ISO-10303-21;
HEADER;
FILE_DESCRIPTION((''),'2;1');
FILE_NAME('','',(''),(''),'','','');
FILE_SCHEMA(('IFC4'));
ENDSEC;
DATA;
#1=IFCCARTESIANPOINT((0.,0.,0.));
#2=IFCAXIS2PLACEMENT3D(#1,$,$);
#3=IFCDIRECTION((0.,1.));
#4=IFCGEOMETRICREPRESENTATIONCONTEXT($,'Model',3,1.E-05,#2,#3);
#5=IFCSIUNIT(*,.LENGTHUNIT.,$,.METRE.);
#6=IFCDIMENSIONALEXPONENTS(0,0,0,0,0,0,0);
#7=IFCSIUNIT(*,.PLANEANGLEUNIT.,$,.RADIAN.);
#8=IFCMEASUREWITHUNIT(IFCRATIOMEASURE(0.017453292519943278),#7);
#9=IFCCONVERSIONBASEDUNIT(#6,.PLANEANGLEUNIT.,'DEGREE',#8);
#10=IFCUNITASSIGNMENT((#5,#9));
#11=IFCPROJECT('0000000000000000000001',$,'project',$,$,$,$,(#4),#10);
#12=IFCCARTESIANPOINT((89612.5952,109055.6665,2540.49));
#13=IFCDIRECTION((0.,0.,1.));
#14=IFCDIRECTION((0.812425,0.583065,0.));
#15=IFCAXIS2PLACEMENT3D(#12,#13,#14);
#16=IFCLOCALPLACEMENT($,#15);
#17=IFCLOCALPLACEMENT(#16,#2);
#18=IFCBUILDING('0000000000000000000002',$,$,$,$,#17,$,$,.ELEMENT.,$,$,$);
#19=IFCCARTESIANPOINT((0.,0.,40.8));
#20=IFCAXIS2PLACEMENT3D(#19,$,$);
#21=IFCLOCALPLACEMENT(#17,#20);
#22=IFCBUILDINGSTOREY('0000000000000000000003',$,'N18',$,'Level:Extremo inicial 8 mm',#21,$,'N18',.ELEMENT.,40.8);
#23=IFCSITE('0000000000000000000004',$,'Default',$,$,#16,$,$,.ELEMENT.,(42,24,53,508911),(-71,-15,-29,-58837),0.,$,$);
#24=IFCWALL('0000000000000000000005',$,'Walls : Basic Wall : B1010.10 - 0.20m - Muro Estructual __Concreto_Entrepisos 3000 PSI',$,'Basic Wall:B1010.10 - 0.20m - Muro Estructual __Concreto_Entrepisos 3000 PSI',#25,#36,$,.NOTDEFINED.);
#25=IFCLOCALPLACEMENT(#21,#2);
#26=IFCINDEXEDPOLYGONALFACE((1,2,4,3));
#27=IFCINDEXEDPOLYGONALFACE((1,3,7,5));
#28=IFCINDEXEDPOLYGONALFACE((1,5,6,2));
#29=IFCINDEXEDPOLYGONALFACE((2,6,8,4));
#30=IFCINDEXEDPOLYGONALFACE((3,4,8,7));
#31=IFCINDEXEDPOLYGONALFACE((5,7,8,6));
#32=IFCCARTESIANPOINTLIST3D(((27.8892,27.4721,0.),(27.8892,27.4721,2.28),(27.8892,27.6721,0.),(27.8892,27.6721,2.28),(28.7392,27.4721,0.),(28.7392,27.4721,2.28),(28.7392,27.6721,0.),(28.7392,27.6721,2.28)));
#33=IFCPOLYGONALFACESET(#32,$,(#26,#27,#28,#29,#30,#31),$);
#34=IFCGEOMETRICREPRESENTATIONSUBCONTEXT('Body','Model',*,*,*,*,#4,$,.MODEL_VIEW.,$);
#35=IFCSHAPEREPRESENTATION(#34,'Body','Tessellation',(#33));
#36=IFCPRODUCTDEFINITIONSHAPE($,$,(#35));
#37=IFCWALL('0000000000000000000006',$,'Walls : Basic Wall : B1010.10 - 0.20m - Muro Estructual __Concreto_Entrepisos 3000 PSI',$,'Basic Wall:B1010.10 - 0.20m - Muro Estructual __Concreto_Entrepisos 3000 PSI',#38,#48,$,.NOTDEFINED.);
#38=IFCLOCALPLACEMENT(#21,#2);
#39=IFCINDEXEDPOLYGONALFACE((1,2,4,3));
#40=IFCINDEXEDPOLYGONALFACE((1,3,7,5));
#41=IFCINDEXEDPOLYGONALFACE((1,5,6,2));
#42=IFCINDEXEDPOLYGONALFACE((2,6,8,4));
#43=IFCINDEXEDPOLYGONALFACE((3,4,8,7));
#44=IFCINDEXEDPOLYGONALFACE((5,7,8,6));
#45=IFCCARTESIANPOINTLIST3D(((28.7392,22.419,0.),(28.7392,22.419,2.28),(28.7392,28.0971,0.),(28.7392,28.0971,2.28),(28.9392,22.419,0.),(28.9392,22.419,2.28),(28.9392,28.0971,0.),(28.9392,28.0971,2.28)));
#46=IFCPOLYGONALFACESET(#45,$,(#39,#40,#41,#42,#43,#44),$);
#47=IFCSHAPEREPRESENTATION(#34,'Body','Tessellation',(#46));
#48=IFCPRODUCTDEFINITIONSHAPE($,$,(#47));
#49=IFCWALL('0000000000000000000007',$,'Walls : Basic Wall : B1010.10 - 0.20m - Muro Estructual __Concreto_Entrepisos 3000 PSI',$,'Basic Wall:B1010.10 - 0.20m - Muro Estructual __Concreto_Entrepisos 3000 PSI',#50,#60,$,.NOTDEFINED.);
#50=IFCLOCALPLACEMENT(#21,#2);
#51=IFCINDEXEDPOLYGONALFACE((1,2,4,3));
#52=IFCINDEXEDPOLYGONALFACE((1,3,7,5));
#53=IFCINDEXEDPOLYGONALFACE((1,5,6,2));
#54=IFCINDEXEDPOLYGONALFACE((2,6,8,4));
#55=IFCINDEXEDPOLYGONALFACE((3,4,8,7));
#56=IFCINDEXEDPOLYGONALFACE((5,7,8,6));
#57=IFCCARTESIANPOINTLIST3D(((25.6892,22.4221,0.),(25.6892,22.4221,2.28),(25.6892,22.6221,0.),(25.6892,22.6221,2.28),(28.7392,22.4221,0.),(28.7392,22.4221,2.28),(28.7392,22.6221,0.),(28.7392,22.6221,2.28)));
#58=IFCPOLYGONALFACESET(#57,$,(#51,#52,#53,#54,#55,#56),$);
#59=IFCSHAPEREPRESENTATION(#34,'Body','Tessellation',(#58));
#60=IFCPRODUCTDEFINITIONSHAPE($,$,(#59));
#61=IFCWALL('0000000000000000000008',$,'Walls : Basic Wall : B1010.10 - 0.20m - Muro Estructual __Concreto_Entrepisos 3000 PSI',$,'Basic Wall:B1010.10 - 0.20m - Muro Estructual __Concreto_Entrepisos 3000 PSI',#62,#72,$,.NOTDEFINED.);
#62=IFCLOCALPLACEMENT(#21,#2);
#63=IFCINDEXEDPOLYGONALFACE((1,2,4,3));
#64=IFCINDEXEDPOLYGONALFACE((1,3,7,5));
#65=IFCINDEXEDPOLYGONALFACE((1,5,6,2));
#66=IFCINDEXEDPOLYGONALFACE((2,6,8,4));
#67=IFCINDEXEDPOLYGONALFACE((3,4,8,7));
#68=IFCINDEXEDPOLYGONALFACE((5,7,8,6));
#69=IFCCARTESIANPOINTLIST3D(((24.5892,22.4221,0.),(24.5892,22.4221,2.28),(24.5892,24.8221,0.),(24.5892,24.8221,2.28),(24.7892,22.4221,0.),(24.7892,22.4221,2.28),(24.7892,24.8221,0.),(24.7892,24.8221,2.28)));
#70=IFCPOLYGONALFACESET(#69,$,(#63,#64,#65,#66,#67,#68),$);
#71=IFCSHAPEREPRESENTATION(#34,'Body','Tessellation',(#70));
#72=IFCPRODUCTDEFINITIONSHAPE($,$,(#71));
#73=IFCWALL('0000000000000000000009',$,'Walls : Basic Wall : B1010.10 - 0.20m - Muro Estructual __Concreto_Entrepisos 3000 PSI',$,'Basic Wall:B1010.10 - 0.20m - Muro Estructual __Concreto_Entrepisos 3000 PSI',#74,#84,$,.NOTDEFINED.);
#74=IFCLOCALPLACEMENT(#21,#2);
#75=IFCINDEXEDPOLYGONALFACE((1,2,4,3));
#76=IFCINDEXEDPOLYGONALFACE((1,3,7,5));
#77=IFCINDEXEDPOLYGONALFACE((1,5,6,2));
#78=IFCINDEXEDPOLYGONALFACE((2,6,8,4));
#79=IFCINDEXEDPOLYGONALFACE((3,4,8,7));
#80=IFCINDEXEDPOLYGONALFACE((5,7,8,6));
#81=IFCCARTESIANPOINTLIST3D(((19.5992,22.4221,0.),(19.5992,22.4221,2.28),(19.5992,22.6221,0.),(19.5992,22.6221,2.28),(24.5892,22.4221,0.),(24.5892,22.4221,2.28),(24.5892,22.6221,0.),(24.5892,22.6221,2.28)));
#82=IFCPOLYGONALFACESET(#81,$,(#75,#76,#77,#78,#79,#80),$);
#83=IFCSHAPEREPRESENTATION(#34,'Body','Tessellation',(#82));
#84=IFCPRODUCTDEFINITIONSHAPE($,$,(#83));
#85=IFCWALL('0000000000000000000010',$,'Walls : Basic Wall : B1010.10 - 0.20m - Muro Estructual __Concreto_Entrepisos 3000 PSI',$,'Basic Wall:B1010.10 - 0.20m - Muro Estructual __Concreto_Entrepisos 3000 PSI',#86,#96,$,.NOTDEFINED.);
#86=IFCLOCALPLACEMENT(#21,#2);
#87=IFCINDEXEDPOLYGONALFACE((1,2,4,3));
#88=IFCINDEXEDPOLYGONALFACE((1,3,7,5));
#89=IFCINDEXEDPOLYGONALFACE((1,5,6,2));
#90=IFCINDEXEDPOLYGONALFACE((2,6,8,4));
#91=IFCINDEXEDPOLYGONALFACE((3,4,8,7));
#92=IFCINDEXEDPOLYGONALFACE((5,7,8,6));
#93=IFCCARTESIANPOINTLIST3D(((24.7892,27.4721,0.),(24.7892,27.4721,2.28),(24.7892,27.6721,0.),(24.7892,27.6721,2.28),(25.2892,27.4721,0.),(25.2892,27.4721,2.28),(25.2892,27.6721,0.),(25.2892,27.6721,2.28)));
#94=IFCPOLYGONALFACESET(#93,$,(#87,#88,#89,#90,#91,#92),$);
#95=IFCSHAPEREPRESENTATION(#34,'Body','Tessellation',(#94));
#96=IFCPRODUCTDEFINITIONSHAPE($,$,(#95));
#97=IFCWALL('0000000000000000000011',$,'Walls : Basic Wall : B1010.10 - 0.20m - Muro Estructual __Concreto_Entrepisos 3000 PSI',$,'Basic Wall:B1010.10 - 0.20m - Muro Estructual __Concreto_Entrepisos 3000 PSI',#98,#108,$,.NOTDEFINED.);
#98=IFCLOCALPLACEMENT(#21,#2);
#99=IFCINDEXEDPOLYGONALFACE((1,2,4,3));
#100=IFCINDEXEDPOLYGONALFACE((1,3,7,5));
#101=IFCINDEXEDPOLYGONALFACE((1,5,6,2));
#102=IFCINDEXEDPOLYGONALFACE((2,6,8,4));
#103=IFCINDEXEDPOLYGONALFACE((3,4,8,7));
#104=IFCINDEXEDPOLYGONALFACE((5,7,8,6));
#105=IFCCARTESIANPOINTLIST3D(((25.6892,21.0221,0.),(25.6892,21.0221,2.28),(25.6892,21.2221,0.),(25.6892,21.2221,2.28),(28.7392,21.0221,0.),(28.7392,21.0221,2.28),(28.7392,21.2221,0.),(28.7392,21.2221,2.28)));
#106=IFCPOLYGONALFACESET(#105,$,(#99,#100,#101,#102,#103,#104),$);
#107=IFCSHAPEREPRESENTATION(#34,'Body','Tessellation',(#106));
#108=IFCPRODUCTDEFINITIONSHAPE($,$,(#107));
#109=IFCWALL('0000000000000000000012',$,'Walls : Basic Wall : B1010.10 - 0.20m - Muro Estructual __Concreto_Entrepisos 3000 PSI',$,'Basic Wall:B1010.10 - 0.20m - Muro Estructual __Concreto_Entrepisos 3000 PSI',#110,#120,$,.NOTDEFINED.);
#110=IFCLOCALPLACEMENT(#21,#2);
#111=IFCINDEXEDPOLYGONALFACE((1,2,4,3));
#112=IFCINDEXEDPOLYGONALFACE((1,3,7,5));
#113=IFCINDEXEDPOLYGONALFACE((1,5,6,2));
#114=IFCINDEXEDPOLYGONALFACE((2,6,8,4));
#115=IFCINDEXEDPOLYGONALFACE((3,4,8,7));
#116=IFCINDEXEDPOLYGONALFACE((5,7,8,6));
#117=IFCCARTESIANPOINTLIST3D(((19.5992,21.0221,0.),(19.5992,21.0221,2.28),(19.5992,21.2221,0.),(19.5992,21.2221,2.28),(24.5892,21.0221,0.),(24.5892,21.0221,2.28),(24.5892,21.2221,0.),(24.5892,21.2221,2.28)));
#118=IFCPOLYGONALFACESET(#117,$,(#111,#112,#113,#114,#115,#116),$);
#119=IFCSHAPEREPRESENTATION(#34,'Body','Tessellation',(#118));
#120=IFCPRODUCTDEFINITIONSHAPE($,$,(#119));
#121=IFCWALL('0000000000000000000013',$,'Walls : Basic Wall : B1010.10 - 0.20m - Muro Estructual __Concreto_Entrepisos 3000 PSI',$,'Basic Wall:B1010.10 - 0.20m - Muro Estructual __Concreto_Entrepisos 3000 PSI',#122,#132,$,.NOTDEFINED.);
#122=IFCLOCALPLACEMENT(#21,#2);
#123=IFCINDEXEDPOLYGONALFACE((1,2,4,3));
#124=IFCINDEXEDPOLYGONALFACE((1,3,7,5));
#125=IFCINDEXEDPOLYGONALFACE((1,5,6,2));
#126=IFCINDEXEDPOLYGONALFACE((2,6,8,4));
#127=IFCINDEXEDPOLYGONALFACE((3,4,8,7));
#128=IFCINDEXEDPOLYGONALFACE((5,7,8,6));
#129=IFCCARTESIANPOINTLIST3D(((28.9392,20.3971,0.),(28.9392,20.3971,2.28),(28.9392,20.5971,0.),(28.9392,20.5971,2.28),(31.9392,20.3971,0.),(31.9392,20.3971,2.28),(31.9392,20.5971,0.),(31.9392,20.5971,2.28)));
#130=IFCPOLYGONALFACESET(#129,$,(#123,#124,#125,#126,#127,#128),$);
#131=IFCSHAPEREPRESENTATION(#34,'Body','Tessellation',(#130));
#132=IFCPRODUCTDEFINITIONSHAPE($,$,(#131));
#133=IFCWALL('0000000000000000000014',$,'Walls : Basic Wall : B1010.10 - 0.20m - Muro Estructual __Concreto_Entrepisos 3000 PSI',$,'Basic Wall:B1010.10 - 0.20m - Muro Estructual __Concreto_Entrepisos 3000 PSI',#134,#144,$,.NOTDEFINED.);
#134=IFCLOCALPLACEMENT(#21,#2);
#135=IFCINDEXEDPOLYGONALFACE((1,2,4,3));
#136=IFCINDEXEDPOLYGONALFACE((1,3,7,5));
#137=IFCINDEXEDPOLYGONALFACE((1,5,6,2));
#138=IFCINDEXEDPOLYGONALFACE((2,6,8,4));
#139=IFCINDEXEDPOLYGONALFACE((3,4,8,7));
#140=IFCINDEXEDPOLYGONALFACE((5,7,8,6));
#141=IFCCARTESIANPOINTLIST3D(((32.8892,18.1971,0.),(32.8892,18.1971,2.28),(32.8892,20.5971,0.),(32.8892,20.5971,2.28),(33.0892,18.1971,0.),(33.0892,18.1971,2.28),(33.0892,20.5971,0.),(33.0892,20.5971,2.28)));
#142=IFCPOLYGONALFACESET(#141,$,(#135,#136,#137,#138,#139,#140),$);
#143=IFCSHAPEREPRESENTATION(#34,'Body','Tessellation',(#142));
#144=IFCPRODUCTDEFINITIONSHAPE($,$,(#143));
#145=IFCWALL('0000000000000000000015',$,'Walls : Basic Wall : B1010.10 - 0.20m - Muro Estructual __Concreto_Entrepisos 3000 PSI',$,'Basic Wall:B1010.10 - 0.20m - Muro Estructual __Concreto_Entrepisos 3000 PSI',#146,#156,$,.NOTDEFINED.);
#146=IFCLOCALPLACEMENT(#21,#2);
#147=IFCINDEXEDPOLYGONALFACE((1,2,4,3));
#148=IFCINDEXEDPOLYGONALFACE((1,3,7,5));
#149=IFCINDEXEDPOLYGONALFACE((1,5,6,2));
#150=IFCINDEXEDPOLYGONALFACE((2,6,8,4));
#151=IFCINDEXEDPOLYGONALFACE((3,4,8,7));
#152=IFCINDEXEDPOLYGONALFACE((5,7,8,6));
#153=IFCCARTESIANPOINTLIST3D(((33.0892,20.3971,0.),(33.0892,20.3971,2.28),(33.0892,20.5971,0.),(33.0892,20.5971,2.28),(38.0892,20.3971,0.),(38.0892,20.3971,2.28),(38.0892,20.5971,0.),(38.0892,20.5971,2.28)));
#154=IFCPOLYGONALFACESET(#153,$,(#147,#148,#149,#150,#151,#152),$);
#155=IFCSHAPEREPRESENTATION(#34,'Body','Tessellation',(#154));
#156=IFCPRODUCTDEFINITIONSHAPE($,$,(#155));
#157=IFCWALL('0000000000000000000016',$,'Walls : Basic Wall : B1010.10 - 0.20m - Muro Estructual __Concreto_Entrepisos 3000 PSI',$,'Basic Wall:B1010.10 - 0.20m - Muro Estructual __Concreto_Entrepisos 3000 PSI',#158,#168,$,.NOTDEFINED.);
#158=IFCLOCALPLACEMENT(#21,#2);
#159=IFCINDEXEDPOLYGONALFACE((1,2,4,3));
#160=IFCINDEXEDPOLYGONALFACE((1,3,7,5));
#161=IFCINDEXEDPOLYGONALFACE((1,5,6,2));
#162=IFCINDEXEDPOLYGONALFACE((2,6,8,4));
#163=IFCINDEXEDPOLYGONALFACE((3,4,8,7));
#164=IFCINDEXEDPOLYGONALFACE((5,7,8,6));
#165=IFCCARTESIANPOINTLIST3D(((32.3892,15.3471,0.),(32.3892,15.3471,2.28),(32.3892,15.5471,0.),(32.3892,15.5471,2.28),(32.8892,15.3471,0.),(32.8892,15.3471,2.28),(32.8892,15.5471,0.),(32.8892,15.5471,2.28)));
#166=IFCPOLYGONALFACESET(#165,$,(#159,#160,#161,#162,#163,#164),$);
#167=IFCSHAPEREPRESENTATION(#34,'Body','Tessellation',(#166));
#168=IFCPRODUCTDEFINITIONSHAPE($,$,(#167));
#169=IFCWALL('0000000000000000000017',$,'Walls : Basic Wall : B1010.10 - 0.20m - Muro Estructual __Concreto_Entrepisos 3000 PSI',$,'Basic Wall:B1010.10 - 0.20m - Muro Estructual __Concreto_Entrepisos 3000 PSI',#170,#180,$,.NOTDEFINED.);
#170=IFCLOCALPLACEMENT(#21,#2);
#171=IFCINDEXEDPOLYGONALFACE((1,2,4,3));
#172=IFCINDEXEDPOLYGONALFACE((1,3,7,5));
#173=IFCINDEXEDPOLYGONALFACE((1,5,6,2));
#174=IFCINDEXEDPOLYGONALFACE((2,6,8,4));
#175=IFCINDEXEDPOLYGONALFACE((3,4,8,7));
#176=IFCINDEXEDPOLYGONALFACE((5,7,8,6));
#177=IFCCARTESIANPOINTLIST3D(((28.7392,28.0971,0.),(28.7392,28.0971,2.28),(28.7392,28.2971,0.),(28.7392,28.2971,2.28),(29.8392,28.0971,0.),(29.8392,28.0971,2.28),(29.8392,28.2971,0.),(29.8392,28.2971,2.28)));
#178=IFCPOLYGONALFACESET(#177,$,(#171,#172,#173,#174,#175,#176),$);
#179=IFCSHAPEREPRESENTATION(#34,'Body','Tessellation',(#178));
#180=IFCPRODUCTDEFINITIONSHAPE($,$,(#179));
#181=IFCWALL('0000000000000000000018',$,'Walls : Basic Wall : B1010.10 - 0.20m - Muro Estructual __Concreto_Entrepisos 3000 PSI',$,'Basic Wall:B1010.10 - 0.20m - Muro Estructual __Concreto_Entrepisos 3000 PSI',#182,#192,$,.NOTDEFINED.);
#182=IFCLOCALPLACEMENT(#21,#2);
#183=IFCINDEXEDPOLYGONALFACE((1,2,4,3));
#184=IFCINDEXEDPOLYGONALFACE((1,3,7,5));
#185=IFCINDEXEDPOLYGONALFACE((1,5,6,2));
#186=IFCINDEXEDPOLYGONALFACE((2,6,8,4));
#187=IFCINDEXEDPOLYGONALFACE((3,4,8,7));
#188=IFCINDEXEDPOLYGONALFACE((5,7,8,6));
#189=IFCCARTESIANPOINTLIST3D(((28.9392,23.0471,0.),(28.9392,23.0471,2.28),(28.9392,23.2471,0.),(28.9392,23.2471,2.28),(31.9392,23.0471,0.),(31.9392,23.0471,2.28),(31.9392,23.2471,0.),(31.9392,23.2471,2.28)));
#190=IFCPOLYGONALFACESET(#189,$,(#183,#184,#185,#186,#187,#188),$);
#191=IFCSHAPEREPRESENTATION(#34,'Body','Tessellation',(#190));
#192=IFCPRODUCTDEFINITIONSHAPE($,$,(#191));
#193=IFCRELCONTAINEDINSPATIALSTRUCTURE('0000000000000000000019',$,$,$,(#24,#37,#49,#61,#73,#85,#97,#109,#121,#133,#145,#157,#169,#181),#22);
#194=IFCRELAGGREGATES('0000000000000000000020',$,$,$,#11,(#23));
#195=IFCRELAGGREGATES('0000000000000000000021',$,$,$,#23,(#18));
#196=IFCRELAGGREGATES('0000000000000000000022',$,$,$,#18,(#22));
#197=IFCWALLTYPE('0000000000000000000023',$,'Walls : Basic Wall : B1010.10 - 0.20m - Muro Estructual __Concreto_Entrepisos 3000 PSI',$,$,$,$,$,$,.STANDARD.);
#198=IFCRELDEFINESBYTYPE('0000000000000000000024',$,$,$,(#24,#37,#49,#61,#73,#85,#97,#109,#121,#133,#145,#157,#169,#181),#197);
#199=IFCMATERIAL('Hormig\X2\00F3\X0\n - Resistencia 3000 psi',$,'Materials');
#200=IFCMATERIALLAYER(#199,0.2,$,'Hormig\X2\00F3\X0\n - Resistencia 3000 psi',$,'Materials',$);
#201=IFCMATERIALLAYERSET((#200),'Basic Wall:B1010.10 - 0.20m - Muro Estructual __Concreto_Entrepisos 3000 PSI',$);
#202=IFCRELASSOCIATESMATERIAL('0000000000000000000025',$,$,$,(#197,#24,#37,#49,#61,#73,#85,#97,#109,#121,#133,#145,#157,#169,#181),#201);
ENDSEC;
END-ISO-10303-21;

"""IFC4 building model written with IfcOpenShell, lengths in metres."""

from ifc_helpers import new_model, entity, si_unit, converted_unit, direction, frame, frame_2d, origin, place, context, subcontext, project, spatial, rectangle, extrude, material, layer, layer_set, layer_usage, type_object, element, save


model = new_model("IFC4")

# Units and contexts
model_context = context("Model", 3, precision=1e-05, world=origin(), true_north=direction((0.0, 1.0)))
body_context = subcontext(model_context, "Body", "Model", "MODEL_VIEW")
ifc_project = project(units=[si_unit("LENGTHUNIT", "METRE"), converted_unit("PLANEANGLEUNIT", "DEGREE", entity("IfcRatioMeasure", 0.017453292519943278), si_unit("PLANEANGLEUNIT", "RADIAN"), dimensions=[0, 0, 0, 0, 0, 0, 0])], contexts=[model_context])

# Site, building, storey
site_placement = place(None, frame((89612.5952, 109055.6665, 2540.49), z_axis=(0.0, 0.0, 1.0), x_axis=(0.812425, 0.583065, 0.0)))
site = spatial("IfcSite", under=ifc_project, at=site_placement, Name="Default", CompositionType="ELEMENT", RefLatitude=(42, 24, 53, 508911), RefLongitude=(-71, -15, -29, -58837), RefElevation=0.0)
building_placement = place(site_placement, origin())
building = spatial("IfcBuilding", under=site, at=building_placement, CompositionType="ELEMENT")
storey_placement = place(building_placement, frame((0.0, 0.0, 40.8)))
storey = spatial("IfcBuildingStorey", under=building, at=storey_placement, Name="N18", ObjectType="Level:Extremo inicial 8 mm", LongName="N18", CompositionType="ELEMENT", Elevation=40.8)

# Walls
ifc_material = material(Name="Hormigón - Resistencia 3000 psi", Category="Materials")
ifc_layer_1 = layer(ifc_material, 0.2, Name="Hormigón - Resistencia 3000 psi", Category="Materials")
ifc_layer_set_1 = layer_set([ifc_layer_1], Name="Basic Wall:B1010.10 - 0.20m - Muro Estructual __Concreto_Entrepisos 3000 PSI")
ifc_layer_usage_1 = layer_usage(ifc_layer_set_1, "AXIS2", "NEGATIVE", 0.1)
wall_type_1 = type_object("IfcWallType", Name="Walls : Basic Wall : B1010.10 - 0.20m - Muro Estructual __Concreto_Entrepisos 3000 PSI", PredefinedType="STANDARD", material=ifc_layer_set_1)
wall_1_placement = place(storey_placement, frame((27.8892, 27.5721, 0.0)))
element("IfcWall", 1, at=wall_1_placement, inside=storey, type_object=wall_type_1, material=ifc_layer_usage_1, Name="Walls : Basic Wall : B1010.10 - 0.20m - Muro Estructual __Concreto_Entrepisos 3000 PSI", ObjectType="Basic Wall:B1010.10 - 0.20m - Muro Estructual __Concreto_Entrepisos 3000 PSI", PredefinedType="NOTDEFINED", context=body_context, shape_type="SweptSolid", body=[
    extrude(rectangle(XDim=0.85, YDim=0.2, at=frame_2d((0.425, 0.0), x_axis=(-1.0, 0.0))), origin(), (0.0, 0.0, 1.0), 2.28),
])
ifc_layer_usage_2 = layer_usage(ifc_layer_set_1, "AXIS2", "NEGATIVE", 0.1)
wall_2_placement = place(storey_placement, frame((28.8392, 28.0971, 0.0), z_axis=(0.0, 0.0, 1.0), x_axis=(0.0, -1.0, 0.0)))
element("IfcWall", 2, at=wall_2_placement, inside=storey, type_object=wall_type_1, material=ifc_layer_usage_2, Name="Walls : Basic Wall : B1010.10 - 0.20m - Muro Estructual __Concreto_Entrepisos 3000 PSI", ObjectType="Basic Wall:B1010.10 - 0.20m - Muro Estructual __Concreto_Entrepisos 3000 PSI", PredefinedType="NOTDEFINED", context=body_context, shape_type="SweptSolid", body=[
    extrude(rectangle(XDim=5.6781, YDim=0.2, at=frame_2d((2.839, 0.0), x_axis=(-1.0, 0.0))), origin(), (0.0, 0.0, 1.0), 2.28),
])
ifc_layer_usage_3 = layer_usage(ifc_layer_set_1, "AXIS2", "NEGATIVE", 0.1)
wall_3_placement = place(storey_placement, frame((28.7392, 22.5221, 0.0), z_axis=(0.0, 0.0, 1.0), x_axis=(-1.0, 0.0, 0.0)))
element("IfcWall", 3, at=wall_3_placement, inside=storey, type_object=wall_type_1, material=ifc_layer_usage_3, Name="Walls : Basic Wall : B1010.10 - 0.20m - Muro Estructual __Concreto_Entrepisos 3000 PSI", ObjectType="Basic Wall:B1010.10 - 0.20m - Muro Estructual __Concreto_Entrepisos 3000 PSI", PredefinedType="NOTDEFINED", context=body_context, shape_type="SweptSolid", body=[
    extrude(rectangle(XDim=3.05, YDim=0.2, at=frame_2d((1.525, 0.0), x_axis=(-1.0, 0.0))), origin(), (0.0, 0.0, 1.0), 2.28),
])
ifc_layer_usage_4 = layer_usage(ifc_layer_set_1, "AXIS2", "NEGATIVE", 0.1)
wall_4_placement = place(storey_placement, frame((24.6892, 24.8221, 0.0), z_axis=(0.0, 0.0, 1.0), x_axis=(0.0, -1.0, 0.0)))
element("IfcWall", 4, at=wall_4_placement, inside=storey, type_object=wall_type_1, material=ifc_layer_usage_4, Name="Walls : Basic Wall : B1010.10 - 0.20m - Muro Estructual __Concreto_Entrepisos 3000 PSI", ObjectType="Basic Wall:B1010.10 - 0.20m - Muro Estructual __Concreto_Entrepisos 3000 PSI", PredefinedType="NOTDEFINED", context=body_context, shape_type="SweptSolid", body=[
    extrude(rectangle(XDim=2.4, YDim=0.2, at=frame_2d((1.2, 0.0), x_axis=(-1.0, 0.0))), origin(), (0.0, 0.0, 1.0), 2.28),
])
ifc_layer_usage_5 = layer_usage(ifc_layer_set_1, "AXIS2", "NEGATIVE", 0.1)
wall_5_placement = place(storey_placement, frame((24.5892, 22.5221, 0.0), z_axis=(0.0, 0.0, 1.0), x_axis=(-1.0, 0.0, 0.0)))
element("IfcWall", 5, at=wall_5_placement, inside=storey, type_object=wall_type_1, material=ifc_layer_usage_5, Name="Walls : Basic Wall : B1010.10 - 0.20m - Muro Estructual __Concreto_Entrepisos 3000 PSI", ObjectType="Basic Wall:B1010.10 - 0.20m - Muro Estructual __Concreto_Entrepisos 3000 PSI", PredefinedType="NOTDEFINED", context=body_context, shape_type="SweptSolid", body=[
    extrude(rectangle(XDim=4.99, YDim=0.2, at=frame_2d((2.495, 0.0), x_axis=(-1.0, 0.0))), origin(), (0.0, 0.0, 1.0), 2.28),
])
ifc_layer_usage_6 = layer_usage(ifc_layer_set_1, "AXIS2", "NEGATIVE", 0.1)
wall_6_placement = place(storey_placement, frame((25.2892, 27.5721, 0.0), z_axis=(0.0, 0.0, 1.0), x_axis=(-1.0, 0.0, 0.0)))
element("IfcWall", 6, at=wall_6_placement, inside=storey, type_object=wall_type_1, material=ifc_layer_usage_6, Name="Walls : Basic Wall : B1010.10 - 0.20m - Muro Estructual __Concreto_Entrepisos 3000 PSI", ObjectType="Basic Wall:B1010.10 - 0.20m - Muro Estructual __Concreto_Entrepisos 3000 PSI", PredefinedType="NOTDEFINED", context=body_context, shape_type="SweptSolid", body=[
    extrude(rectangle(XDim=0.5, YDim=0.2, at=frame_2d((0.25, 0.0), x_axis=(-1.0, 0.0))), origin(), (0.0, 0.0, 1.0), 2.28),
])
ifc_layer_usage_7 = layer_usage(ifc_layer_set_1, "AXIS2", "POSITIVE", -0.1)
wall_7_placement = place(storey_placement, frame((28.7392, 21.1221, 0.0), z_axis=(0.0, 0.0, 1.0), x_axis=(-1.0, 0.0, 0.0)))
element("IfcWall", 7, at=wall_7_placement, inside=storey, type_object=wall_type_1, material=ifc_layer_usage_7, Name="Walls : Basic Wall : B1010.10 - 0.20m - Muro Estructual __Concreto_Entrepisos 3000 PSI", ObjectType="Basic Wall:B1010.10 - 0.20m - Muro Estructual __Concreto_Entrepisos 3000 PSI", PredefinedType="NOTDEFINED", context=body_context, shape_type="SweptSolid", body=[
    extrude(rectangle(XDim=3.05, YDim=0.2, at=frame_2d((1.525, 0.0), x_axis=(-1.0, 0.0))), origin(), (0.0, 0.0, 1.0), 2.28),
])
ifc_layer_usage_8 = layer_usage(ifc_layer_set_1, "AXIS2", "POSITIVE", -0.1)
wall_8_placement = place(storey_placement, frame((24.5892, 21.1221, 0.0), z_axis=(0.0, 0.0, 1.0), x_axis=(-1.0, 0.0, 0.0)))
element("IfcWall", 8, at=wall_8_placement, inside=storey, type_object=wall_type_1, material=ifc_layer_usage_8, Name="Walls : Basic Wall : B1010.10 - 0.20m - Muro Estructual __Concreto_Entrepisos 3000 PSI", ObjectType="Basic Wall:B1010.10 - 0.20m - Muro Estructual __Concreto_Entrepisos 3000 PSI", PredefinedType="NOTDEFINED", context=body_context, shape_type="SweptSolid", body=[
    extrude(rectangle(XDim=4.99, YDim=0.2, at=frame_2d((2.495, 0.0), x_axis=(-1.0, 0.0))), origin(), (0.0, 0.0, 1.0), 2.28),
])
ifc_layer_usage_9 = layer_usage(ifc_layer_set_1, "AXIS2", "NEGATIVE", 0.1)
wall_9_placement = place(storey_placement, frame((28.9392, 20.4971, 0.0)))
element("IfcWall", 9, at=wall_9_placement, inside=storey, type_object=wall_type_1, material=ifc_layer_usage_9, Name="Walls : Basic Wall : B1010.10 - 0.20m - Muro Estructual __Concreto_Entrepisos 3000 PSI", ObjectType="Basic Wall:B1010.10 - 0.20m - Muro Estructual __Concreto_Entrepisos 3000 PSI", PredefinedType="NOTDEFINED", context=body_context, shape_type="SweptSolid", body=[
    extrude(rectangle(XDim=3.0, YDim=0.2, at=frame_2d((1.5, 0.0), x_axis=(-1.0, 0.0))), origin(), (0.0, 0.0, 1.0), 2.28),
])
ifc_layer_usage_10 = layer_usage(ifc_layer_set_1, "AXIS2", "NEGATIVE", 0.1)
wall_10_placement = place(storey_placement, frame((32.9892, 18.1971, 0.0), z_axis=(0.0, 0.0, 1.0), x_axis=(0.0, 1.0, 0.0)))
element("IfcWall", 10, at=wall_10_placement, inside=storey, type_object=wall_type_1, material=ifc_layer_usage_10, Name="Walls : Basic Wall : B1010.10 - 0.20m - Muro Estructual __Concreto_Entrepisos 3000 PSI", ObjectType="Basic Wall:B1010.10 - 0.20m - Muro Estructual __Concreto_Entrepisos 3000 PSI", PredefinedType="NOTDEFINED", context=body_context, shape_type="SweptSolid", body=[
    extrude(rectangle(XDim=2.4, YDim=0.2, at=frame_2d((1.2, 0.0), x_axis=(-1.0, 0.0))), origin(), (0.0, 0.0, 1.0), 2.28),
])
ifc_layer_usage_11 = layer_usage(ifc_layer_set_1, "AXIS2", "NEGATIVE", 0.1)
wall_11_placement = place(storey_placement, frame((33.0892, 20.4971, 0.0)))
element("IfcWall", 11, at=wall_11_placement, inside=storey, type_object=wall_type_1, material=ifc_layer_usage_11, Name="Walls : Basic Wall : B1010.10 - 0.20m - Muro Estructual __Concreto_Entrepisos 3000 PSI", ObjectType="Basic Wall:B1010.10 - 0.20m - Muro Estructual __Concreto_Entrepisos 3000 PSI", PredefinedType="NOTDEFINED", context=body_context, shape_type="SweptSolid", body=[
    extrude(rectangle(XDim=5.0, YDim=0.2, at=frame_2d((2.5, 0.0), x_axis=(-1.0, 0.0))), origin(), (0.0, 0.0, 1.0), 2.28),
])
ifc_layer_usage_12 = layer_usage(ifc_layer_set_1, "AXIS2", "NEGATIVE", 0.1)
wall_12_placement = place(storey_placement, frame((32.3892, 15.4471, 0.0)))
element("IfcWall", 12, at=wall_12_placement, inside=storey, type_object=wall_type_1, material=ifc_layer_usage_12, Name="Walls : Basic Wall : B1010.10 - 0.20m - Muro Estructual __Concreto_Entrepisos 3000 PSI", ObjectType="Basic Wall:B1010.10 - 0.20m - Muro Estructual __Concreto_Entrepisos 3000 PSI", PredefinedType="NOTDEFINED", context=body_context, shape_type="SweptSolid", body=[
    extrude(rectangle(XDim=0.5, YDim=0.2, at=frame_2d((0.25, 0.0), x_axis=(-1.0, 0.0))), origin(), (0.0, 0.0, 1.0), 2.28),
])
ifc_layer_usage_13 = layer_usage(ifc_layer_set_1, "AXIS2", "POSITIVE", -0.1)
wall_13_placement = place(storey_placement, frame((29.8392, 28.1971, 0.0), z_axis=(0.0, 0.0, 1.0), x_axis=(-1.0, 0.0, 0.0)))
element("IfcWall", 13, at=wall_13_placement, inside=storey, type_object=wall_type_1, material=ifc_layer_usage_13, Name="Walls : Basic Wall : B1010.10 - 0.20m - Muro Estructual __Concreto_Entrepisos 3000 PSI", ObjectType="Basic Wall:B1010.10 - 0.20m - Muro Estructual __Concreto_Entrepisos 3000 PSI", PredefinedType="NOTDEFINED", context=body_context, shape_type="SweptSolid", body=[
    extrude(rectangle(XDim=1.1, YDim=0.2, at=frame_2d((0.55, 0.0), x_axis=(-1.0, 0.0))), origin(), (0.0, 0.0, 1.0), 2.28),
])
ifc_layer_usage_14 = layer_usage(ifc_layer_set_1, "AXIS2", "POSITIVE", -0.1)
wall_14_placement = place(storey_placement, frame((28.9392, 23.1471, 0.0)))
element("IfcWall", 14, at=wall_14_placement, inside=storey, type_object=wall_type_1, material=ifc_layer_usage_14, Name="Walls : Basic Wall : B1010.10 - 0.20m - Muro Estructual __Concreto_Entrepisos 3000 PSI", ObjectType="Basic Wall:B1010.10 - 0.20m - Muro Estructual __Concreto_Entrepisos 3000 PSI", PredefinedType="NOTDEFINED", context=body_context, shape_type="SweptSolid", body=[
    extrude(rectangle(XDim=3.0, YDim=0.2, at=frame_2d((1.5, 0.0), x_axis=(-1.0, 0.0))), origin(), (0.0, 0.0, 1.0), 2.28),
])

save(model, "model.ifc")
